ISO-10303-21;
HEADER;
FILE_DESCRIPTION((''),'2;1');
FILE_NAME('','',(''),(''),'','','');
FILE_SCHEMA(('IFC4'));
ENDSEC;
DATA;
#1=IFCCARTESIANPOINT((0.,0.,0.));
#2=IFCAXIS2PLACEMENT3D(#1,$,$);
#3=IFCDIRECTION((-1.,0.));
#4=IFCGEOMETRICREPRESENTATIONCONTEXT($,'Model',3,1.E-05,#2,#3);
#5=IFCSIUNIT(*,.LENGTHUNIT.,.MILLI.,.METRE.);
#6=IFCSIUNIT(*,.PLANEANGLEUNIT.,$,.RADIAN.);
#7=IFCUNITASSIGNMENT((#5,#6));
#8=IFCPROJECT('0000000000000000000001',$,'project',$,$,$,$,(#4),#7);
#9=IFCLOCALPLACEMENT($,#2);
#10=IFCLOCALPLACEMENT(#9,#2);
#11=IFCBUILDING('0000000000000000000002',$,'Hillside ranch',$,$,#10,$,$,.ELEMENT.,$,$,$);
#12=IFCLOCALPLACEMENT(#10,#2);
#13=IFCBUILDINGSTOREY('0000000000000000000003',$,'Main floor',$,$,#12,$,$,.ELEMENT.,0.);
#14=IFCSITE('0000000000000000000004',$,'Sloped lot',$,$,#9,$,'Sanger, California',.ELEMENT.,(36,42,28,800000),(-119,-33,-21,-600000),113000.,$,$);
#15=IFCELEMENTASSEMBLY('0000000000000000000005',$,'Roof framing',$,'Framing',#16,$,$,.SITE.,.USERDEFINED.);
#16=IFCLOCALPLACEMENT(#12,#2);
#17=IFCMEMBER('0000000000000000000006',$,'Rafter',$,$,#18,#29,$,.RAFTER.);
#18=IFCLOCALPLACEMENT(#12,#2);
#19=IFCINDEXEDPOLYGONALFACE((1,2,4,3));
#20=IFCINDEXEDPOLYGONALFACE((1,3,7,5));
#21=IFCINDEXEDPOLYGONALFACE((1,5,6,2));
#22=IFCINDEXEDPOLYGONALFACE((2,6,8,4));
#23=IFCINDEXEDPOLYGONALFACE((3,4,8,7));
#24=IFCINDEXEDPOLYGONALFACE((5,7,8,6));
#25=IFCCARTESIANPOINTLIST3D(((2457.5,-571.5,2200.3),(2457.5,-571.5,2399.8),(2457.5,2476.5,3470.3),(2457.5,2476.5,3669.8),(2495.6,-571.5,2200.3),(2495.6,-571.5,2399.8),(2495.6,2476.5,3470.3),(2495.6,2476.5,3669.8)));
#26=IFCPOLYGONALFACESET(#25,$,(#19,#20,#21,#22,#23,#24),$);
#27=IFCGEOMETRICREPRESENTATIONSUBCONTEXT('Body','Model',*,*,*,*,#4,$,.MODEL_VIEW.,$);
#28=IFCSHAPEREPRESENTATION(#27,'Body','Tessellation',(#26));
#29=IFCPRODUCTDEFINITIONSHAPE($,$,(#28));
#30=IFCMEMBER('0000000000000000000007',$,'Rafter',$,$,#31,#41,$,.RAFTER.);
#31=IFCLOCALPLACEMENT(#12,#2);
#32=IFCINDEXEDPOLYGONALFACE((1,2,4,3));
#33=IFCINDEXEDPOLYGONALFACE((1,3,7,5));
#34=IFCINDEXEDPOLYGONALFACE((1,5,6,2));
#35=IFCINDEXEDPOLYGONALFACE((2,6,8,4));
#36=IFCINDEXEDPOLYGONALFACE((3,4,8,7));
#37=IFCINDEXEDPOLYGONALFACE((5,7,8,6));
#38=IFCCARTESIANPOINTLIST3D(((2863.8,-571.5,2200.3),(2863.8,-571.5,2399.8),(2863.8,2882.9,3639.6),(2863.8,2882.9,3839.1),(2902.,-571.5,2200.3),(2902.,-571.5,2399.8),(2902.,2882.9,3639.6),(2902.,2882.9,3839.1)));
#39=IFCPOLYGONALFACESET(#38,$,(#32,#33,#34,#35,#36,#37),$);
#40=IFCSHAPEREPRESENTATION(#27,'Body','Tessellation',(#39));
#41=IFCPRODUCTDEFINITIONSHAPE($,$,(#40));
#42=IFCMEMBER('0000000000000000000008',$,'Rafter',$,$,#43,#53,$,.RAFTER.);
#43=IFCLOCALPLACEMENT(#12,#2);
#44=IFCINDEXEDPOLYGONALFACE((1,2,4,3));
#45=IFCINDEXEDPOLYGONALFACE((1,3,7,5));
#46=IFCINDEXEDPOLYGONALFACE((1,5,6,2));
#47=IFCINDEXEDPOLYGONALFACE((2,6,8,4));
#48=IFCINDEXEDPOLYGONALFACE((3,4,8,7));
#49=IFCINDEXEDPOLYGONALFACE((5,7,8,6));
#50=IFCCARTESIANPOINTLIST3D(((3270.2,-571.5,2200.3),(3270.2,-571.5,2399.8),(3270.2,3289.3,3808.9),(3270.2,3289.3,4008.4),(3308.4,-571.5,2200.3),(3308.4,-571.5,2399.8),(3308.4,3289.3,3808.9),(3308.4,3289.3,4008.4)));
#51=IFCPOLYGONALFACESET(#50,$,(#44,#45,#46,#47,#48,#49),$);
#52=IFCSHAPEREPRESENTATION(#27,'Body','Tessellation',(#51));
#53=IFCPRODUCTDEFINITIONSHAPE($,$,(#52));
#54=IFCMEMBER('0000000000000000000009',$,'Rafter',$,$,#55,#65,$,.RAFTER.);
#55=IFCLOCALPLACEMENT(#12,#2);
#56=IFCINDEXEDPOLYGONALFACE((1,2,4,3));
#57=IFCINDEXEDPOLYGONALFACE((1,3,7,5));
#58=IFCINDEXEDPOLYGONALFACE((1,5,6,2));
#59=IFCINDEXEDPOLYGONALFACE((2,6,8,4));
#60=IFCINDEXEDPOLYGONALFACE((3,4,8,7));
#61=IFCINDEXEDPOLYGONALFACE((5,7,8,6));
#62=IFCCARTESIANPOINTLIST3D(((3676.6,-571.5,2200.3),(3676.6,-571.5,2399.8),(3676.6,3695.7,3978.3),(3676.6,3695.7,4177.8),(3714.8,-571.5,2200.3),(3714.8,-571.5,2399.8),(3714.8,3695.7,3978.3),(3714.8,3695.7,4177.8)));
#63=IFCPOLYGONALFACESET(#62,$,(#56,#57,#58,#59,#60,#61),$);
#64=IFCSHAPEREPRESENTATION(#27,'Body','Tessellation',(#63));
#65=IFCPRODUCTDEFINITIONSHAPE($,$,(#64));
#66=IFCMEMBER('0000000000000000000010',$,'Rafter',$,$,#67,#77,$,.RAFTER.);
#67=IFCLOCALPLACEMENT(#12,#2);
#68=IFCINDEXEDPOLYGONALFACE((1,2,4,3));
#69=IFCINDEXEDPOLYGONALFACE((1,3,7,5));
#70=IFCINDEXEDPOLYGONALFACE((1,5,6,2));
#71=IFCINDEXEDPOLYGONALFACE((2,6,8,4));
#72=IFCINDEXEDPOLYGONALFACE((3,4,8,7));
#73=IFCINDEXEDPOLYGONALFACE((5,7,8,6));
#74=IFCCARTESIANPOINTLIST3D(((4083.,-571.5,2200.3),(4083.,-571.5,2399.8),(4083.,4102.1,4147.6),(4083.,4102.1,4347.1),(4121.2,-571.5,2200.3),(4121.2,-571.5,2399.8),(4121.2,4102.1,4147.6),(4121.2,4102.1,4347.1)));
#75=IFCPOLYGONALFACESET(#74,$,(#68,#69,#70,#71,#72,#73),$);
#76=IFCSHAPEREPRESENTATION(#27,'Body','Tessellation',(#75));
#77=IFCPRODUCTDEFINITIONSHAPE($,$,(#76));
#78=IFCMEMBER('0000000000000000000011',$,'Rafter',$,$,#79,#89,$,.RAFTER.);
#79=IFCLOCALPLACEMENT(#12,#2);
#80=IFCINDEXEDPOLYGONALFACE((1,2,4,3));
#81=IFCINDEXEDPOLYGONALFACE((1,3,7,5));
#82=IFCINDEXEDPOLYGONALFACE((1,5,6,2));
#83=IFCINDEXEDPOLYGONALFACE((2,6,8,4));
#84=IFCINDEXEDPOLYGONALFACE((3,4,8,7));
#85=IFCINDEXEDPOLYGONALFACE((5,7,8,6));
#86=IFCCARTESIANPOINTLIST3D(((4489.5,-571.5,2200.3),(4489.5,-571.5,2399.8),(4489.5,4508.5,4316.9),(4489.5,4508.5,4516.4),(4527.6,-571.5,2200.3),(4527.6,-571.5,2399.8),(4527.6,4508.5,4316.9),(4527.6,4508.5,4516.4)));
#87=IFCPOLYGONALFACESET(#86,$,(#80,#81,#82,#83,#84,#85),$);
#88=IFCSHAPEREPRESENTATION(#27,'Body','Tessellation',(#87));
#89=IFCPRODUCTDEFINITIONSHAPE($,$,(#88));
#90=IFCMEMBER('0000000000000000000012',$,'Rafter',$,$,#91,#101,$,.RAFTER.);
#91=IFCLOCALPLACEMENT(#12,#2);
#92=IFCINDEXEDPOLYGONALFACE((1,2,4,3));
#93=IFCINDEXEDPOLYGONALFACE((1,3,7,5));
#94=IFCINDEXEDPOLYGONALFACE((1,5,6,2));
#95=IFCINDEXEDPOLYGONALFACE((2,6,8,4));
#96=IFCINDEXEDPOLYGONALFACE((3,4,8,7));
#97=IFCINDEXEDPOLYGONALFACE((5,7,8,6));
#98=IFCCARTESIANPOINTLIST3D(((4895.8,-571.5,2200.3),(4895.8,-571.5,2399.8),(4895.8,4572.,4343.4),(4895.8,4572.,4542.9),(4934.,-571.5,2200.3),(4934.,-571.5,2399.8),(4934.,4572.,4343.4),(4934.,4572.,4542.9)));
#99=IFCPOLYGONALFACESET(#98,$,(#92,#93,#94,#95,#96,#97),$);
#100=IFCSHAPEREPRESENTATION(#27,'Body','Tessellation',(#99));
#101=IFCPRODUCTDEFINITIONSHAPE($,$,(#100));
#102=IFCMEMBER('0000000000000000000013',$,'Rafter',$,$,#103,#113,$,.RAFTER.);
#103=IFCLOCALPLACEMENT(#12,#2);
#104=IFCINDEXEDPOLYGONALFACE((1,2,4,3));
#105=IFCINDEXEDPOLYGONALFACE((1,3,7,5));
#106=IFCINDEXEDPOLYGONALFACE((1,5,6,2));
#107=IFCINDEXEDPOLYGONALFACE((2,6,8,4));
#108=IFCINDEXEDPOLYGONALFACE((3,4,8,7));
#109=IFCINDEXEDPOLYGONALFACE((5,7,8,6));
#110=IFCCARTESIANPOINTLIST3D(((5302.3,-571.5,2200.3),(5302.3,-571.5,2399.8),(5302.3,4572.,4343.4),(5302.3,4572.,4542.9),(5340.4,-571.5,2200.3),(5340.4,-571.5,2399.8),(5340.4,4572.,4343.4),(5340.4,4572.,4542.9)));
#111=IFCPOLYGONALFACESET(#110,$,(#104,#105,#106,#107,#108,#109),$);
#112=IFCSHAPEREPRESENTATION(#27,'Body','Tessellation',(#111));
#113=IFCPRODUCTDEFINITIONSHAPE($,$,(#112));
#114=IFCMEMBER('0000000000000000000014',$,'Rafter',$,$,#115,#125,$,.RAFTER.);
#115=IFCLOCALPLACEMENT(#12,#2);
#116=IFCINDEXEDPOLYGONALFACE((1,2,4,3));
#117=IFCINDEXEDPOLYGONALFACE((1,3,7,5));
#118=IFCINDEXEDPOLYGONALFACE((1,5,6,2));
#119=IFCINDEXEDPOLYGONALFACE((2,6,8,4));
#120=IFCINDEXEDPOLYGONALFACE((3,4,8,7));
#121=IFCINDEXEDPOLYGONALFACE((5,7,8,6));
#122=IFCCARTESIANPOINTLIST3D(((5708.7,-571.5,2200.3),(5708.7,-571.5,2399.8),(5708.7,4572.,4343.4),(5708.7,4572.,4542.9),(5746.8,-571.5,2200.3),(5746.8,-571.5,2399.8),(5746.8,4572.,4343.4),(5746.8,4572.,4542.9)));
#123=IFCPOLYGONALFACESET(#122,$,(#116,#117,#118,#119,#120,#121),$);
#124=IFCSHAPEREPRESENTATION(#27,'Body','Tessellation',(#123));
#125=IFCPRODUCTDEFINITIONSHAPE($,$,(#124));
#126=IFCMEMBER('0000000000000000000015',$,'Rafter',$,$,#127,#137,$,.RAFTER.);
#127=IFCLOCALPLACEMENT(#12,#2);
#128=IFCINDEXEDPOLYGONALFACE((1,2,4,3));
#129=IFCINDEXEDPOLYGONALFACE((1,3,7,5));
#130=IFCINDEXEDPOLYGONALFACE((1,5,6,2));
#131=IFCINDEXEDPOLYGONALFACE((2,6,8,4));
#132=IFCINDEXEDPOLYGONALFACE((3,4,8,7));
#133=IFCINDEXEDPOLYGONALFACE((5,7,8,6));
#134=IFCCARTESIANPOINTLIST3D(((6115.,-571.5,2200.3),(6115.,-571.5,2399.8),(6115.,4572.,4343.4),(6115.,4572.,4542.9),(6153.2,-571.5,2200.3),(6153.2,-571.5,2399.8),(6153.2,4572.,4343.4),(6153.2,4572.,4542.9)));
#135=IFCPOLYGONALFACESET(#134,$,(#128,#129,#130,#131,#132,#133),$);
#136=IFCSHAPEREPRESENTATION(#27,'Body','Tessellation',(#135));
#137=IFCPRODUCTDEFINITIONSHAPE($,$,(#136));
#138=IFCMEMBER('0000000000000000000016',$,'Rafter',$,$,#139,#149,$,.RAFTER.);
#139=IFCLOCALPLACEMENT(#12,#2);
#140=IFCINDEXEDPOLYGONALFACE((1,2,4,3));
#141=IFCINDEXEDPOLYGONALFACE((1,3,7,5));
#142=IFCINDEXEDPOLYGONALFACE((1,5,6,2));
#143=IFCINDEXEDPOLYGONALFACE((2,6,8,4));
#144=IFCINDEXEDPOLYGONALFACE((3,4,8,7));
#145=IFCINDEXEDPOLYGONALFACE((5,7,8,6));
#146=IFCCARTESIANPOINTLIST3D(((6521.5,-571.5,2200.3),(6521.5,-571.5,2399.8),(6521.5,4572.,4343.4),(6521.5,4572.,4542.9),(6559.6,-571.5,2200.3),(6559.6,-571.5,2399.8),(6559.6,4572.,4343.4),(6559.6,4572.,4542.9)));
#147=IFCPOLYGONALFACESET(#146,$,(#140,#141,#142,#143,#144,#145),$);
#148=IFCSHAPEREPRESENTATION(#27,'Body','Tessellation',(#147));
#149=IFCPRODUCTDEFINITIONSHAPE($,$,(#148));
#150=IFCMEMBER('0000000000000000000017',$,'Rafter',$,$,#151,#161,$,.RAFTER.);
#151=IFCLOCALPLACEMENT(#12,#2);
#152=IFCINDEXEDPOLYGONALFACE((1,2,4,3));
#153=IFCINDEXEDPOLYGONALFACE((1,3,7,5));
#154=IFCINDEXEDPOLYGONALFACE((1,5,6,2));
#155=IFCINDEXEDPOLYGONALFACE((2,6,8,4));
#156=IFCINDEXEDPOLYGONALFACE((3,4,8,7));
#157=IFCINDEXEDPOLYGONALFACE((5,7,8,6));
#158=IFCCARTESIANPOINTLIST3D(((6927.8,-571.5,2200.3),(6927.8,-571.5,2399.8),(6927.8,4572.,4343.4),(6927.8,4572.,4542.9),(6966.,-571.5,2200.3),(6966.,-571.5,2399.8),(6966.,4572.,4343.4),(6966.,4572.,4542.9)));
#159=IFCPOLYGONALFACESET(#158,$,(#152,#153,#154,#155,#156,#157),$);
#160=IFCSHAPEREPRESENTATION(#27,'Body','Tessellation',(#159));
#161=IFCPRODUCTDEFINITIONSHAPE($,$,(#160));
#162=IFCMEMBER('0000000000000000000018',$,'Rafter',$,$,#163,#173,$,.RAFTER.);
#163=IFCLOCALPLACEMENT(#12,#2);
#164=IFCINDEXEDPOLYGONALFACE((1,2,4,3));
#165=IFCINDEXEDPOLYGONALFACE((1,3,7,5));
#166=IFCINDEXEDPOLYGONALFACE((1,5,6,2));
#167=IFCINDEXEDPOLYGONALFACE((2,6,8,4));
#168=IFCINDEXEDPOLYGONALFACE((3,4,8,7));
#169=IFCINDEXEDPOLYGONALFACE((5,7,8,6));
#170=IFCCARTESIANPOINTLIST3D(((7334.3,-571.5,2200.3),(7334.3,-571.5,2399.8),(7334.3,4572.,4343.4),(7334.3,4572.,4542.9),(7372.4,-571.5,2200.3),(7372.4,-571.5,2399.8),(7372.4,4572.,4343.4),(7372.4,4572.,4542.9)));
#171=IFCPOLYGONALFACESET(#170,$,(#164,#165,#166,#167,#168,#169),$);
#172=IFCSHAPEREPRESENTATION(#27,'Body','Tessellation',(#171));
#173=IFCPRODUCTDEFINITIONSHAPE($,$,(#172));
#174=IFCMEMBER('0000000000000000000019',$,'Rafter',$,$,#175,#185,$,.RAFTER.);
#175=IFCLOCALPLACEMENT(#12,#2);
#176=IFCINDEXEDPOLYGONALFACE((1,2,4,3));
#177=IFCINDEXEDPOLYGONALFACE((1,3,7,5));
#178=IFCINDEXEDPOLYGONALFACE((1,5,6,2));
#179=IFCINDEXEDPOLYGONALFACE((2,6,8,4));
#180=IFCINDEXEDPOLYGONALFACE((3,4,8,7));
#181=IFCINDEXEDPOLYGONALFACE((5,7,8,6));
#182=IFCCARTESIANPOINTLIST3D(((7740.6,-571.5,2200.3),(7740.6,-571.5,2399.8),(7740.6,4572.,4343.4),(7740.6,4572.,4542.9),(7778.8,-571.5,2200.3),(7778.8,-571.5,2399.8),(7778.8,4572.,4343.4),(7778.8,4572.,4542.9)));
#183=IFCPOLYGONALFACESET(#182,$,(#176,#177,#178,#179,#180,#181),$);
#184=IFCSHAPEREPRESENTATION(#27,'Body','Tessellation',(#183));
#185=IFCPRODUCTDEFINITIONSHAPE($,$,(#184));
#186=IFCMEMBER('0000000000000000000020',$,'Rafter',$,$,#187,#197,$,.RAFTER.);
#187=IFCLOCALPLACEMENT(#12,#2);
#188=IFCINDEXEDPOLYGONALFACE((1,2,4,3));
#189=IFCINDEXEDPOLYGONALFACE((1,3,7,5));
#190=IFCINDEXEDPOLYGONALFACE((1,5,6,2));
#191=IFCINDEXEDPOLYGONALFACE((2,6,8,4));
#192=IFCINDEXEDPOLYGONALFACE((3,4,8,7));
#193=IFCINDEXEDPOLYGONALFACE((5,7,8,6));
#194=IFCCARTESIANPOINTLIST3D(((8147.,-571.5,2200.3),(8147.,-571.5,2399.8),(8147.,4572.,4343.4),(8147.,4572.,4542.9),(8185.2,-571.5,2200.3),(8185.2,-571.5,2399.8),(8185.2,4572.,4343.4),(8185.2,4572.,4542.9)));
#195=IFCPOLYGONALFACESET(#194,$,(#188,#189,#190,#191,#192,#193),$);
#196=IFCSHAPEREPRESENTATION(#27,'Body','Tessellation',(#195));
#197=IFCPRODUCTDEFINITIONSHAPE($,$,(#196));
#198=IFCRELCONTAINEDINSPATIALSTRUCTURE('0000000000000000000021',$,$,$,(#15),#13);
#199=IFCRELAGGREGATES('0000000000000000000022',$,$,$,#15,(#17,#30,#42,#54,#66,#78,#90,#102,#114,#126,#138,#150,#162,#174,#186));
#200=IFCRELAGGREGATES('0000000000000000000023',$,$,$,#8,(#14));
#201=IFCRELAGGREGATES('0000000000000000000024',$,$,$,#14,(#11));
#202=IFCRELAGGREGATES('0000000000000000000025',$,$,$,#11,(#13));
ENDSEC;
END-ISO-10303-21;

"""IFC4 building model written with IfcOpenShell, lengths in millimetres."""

from ifc_helpers import new_model, si_unit, direction, frame, origin, origin_with_axes, place, context, subcontext, project, spatial, polyline, outline, extrude, element, aggregate, save


model = new_model("IFC4")

# Units and contexts
model_context = context("Model", 3, precision=1e-05, world=origin(), true_north=direction((-1.0, 0.0)))
body_context = subcontext(model_context, "Body", "Model", "MODEL_VIEW")
ifc_project = project(units=[si_unit("LENGTHUNIT", "METRE", prefix="MILLI"), si_unit("PLANEANGLEUNIT", "RADIAN")], contexts=[model_context])

# Site, building, storey
site_placement = place(None, origin())
site = spatial("IfcSite", under=ifc_project, at=site_placement, Name="Sloped lot", LongName="Sanger, California", CompositionType="ELEMENT", RefLatitude=(36, 42, 28, 800000), RefLongitude=(-119, -33, -21, -600000), RefElevation=113000.0)
building_placement = place(site_placement, origin())
building = spatial("IfcBuilding", under=site, at=building_placement, Name="Hillside ranch", CompositionType="ELEMENT")
storey_placement = place(building_placement, origin())
storey = spatial("IfcBuildingStorey", under=building, at=storey_placement, Name="Main floor", CompositionType="ELEMENT", Elevation=0.0)

# Element assembly, members
assembly_placement = place(storey_placement, origin_with_axes())
assembly = element("IfcElementAssembly", 1, at=assembly_placement, inside=storey, Name="Roof framing", ObjectType="Framing", AssemblyPlace="SITE", PredefinedType="USERDEFINED")
member_1_placement = place(storey_placement, origin_with_axes())
member_1 = element("IfcMember", 2, at=member_1_placement, Name="Rafter", PredefinedType="RAFTER", context=body_context, shape_type="SweptSolid", body=[
    extrude(outline(polyline([(0.0, 0.0), (38.1, 0.0), (38.1, 199.5), (0.0, 199.5), (0.0, 0.0)])), frame((2495.6, -571.5, 2200.3), z_axis=(0.0, 1.0, 0.0), x_axis=(-1.0, 0.0, 0.0)), (0.0, 0.384615, 0.923077), 3302.0),
])
member_2_placement = place(storey_placement, origin_with_axes())
member_2 = element("IfcMember", 3, at=member_2_placement, Name="Rafter", PredefinedType="RAFTER", context=body_context, shape_type="SweptSolid", body=[
    extrude(outline(polyline([(0.0, 0.0), (38.1, 0.0), (38.1, 199.5), (0.0, 199.5), (0.0, 0.0)])), frame((2901.9, -571.5, 2200.3), z_axis=(0.0, 1.0, 0.0), x_axis=(-1.0, 0.0, 0.0)), (0.0, 0.384615, 0.923077), 3742.3),
])
member_3_placement = place(storey_placement, origin_with_axes())
member_3 = element("IfcMember", 4, at=member_3_placement, Name="Rafter", PredefinedType="RAFTER", context=body_context, shape_type="SweptSolid", body=[
    extrude(outline(polyline([(0.0, 0.0), (38.1, 0.0), (38.1, 199.5), (0.0, 199.5), (0.0, 0.0)])), frame((3308.3, -571.5, 2200.3), z_axis=(0.0, 1.0, 0.0), x_axis=(-1.0, 0.0, 0.0)), (0.0, 0.384615, 0.923077), 4182.5),
])
member_4_placement = place(storey_placement, origin_with_axes())
member_4 = element("IfcMember", 5, at=member_4_placement, Name="Rafter", PredefinedType="RAFTER", context=body_context, shape_type="SweptSolid", body=[
    extrude(outline(polyline([(0.0, 0.0), (38.1, 0.0), (38.1, 199.5), (0.0, 199.5), (0.0, 0.0)])), frame((3714.8, -571.5, 2200.3), z_axis=(0.0, 1.0, 0.0), x_axis=(-1.0, 0.0, 0.0)), (0.0, 0.384615, 0.923077), 4622.8),
])
member_5_placement = place(storey_placement, origin_with_axes())
member_5 = element("IfcMember", 6, at=member_5_placement, Name="Rafter", PredefinedType="RAFTER", context=body_context, shape_type="SweptSolid", body=[
    extrude(outline(polyline([(0.0, 0.0), (38.1, 0.0), (38.1, 199.5), (0.0, 199.5), (0.0, 0.0)])), frame((4121.1, -571.5, 2200.3), z_axis=(0.0, 1.0, 0.0), x_axis=(-1.0, 0.0, 0.0)), (0.0, 0.384615, 0.923077), 5063.1),
])
member_6_placement = place(storey_placement, origin_with_axes())
member_6 = element("IfcMember", 7, at=member_6_placement, Name="Rafter", PredefinedType="RAFTER", context=body_context, shape_type="SweptSolid", body=[
    extrude(outline(polyline([(0.0, 0.0), (38.1, 0.0), (38.1, 199.5), (0.0, 199.5), (0.0, 0.0)])), frame((4527.6, -571.5, 2200.3), z_axis=(0.0, 1.0, 0.0), x_axis=(-1.0, 0.0, 0.0)), (0.0, 0.384615, 0.923077), 5503.3),
])
member_7_placement = place(storey_placement, origin_with_axes())
member_7 = element("IfcMember", 8, at=member_7_placement, Name="Rafter", PredefinedType="RAFTER", context=body_context, shape_type="SweptSolid", body=[
    extrude(outline(polyline([(0.0, 0.0), (38.1, 0.0), (38.1, 199.5), (0.0, 199.5), (0.0, 0.0)])), frame((4933.9, -571.5, 2200.3), z_axis=(0.0, 1.0, 0.0), x_axis=(-1.0, 0.0, 0.0)), (0.0, 0.384615, 0.923077), 5572.1),
])
member_8_placement = place(storey_placement, origin_with_axes())
member_8 = element("IfcMember", 9, at=member_8_placement, Name="Rafter", PredefinedType="RAFTER", context=body_context, shape_type="SweptSolid", body=[
    extrude(outline(polyline([(0.0, 0.0), (38.1, 0.0), (38.1, 199.5), (0.0, 199.5), (0.0, 0.0)])), frame((5340.4, -571.5, 2200.3), z_axis=(0.0, 1.0, 0.0), x_axis=(-1.0, 0.0, 0.0)), (0.0, 0.384615, 0.923077), 5572.1),
])
member_9_placement = place(storey_placement, origin_with_axes())
member_9 = element("IfcMember", 10, at=member_9_placement, Name="Rafter", PredefinedType="RAFTER", context=body_context, shape_type="SweptSolid", body=[
    extrude(outline(polyline([(0.0, 0.0), (38.1, 0.0), (38.1, 199.5), (0.0, 199.5), (0.0, 0.0)])), frame((5746.8, -571.5, 2200.3), z_axis=(0.0, 1.0, 0.0), x_axis=(-1.0, 0.0, 0.0)), (0.0, 0.384615, 0.923077), 5572.1),
])
member_10_placement = place(storey_placement, origin_with_axes())
member_10 = element("IfcMember", 11, at=member_10_placement, Name="Rafter", PredefinedType="RAFTER", context=body_context, shape_type="SweptSolid", body=[
    extrude(outline(polyline([(0.0, 0.0), (38.1, 0.0), (38.1, 199.5), (0.0, 199.5), (0.0, 0.0)])), frame((6153.1, -571.5, 2200.3), z_axis=(0.0, 1.0, 0.0), x_axis=(-1.0, 0.0, 0.0)), (0.0, 0.384615, 0.923077), 5572.1),
])
member_11_placement = place(storey_placement, origin_with_axes())
member_11 = element("IfcMember", 12, at=member_11_placement, Name="Rafter", PredefinedType="RAFTER", context=body_context, shape_type="SweptSolid", body=[
    extrude(outline(polyline([(0.0, 0.0), (38.1, 0.0), (38.1, 199.5), (0.0, 199.5), (0.0, 0.0)])), frame((6559.6, -571.5, 2200.3), z_axis=(0.0, 1.0, 0.0), x_axis=(-1.0, 0.0, 0.0)), (0.0, 0.384615, 0.923077), 5572.1),
])
member_12_placement = place(storey_placement, origin_with_axes())
member_12 = element("IfcMember", 13, at=member_12_placement, Name="Rafter", PredefinedType="RAFTER", context=body_context, shape_type="SweptSolid", body=[
    extrude(outline(polyline([(0.0, 0.0), (38.1, 0.0), (38.1, 199.5), (0.0, 199.5), (0.0, 0.0)])), frame((6965.9, -571.5, 2200.3), z_axis=(0.0, 1.0, 0.0), x_axis=(-1.0, 0.0, 0.0)), (0.0, 0.384615, 0.923077), 5572.1),
])
member_13_placement = place(storey_placement, origin_with_axes())
member_13 = element("IfcMember", 14, at=member_13_placement, Name="Rafter", PredefinedType="RAFTER", context=body_context, shape_type="SweptSolid", body=[
    extrude(outline(polyline([(0.0, 0.0), (38.1, 0.0), (38.1, 199.5), (0.0, 199.5), (0.0, 0.0)])), frame((7372.4, -571.5, 2200.3), z_axis=(0.0, 1.0, 0.0), x_axis=(-1.0, 0.0, 0.0)), (0.0, 0.384615, 0.923077), 5572.1),
])
member_14_placement = place(storey_placement, origin_with_axes())
member_14 = element("IfcMember", 15, at=member_14_placement, Name="Rafter", PredefinedType="RAFTER", context=body_context, shape_type="SweptSolid", body=[
    extrude(outline(polyline([(0.0, 0.0), (38.1, 0.0), (38.1, 199.5), (0.0, 199.5), (0.0, 0.0)])), frame((7778.8, -571.5, 2200.3), z_axis=(0.0, 1.0, 0.0), x_axis=(-1.0, 0.0, 0.0)), (0.0, 0.384615, 0.923077), 5572.1),
])
member_15_placement = place(storey_placement, origin_with_axes())
member_15 = element("IfcMember", 16, at=member_15_placement, Name="Rafter", PredefinedType="RAFTER", context=body_context, shape_type="SweptSolid", body=[
    extrude(outline(polyline([(0.0, 0.0), (38.1, 0.0), (38.1, 199.5), (0.0, 199.5), (0.0, 0.0)])), frame((8185.1, -571.5, 2200.3), z_axis=(0.0, 1.0, 0.0), x_axis=(-1.0, 0.0, 0.0)), (0.0, 0.384615, 0.923077), 5572.1),
])
aggregate(assembly, [member_1, member_2, member_3, member_4, member_5, member_6, member_7, member_8, member_9, member_10, member_11, member_12, member_13, member_14, member_15])

save(model, "model.ifc")
